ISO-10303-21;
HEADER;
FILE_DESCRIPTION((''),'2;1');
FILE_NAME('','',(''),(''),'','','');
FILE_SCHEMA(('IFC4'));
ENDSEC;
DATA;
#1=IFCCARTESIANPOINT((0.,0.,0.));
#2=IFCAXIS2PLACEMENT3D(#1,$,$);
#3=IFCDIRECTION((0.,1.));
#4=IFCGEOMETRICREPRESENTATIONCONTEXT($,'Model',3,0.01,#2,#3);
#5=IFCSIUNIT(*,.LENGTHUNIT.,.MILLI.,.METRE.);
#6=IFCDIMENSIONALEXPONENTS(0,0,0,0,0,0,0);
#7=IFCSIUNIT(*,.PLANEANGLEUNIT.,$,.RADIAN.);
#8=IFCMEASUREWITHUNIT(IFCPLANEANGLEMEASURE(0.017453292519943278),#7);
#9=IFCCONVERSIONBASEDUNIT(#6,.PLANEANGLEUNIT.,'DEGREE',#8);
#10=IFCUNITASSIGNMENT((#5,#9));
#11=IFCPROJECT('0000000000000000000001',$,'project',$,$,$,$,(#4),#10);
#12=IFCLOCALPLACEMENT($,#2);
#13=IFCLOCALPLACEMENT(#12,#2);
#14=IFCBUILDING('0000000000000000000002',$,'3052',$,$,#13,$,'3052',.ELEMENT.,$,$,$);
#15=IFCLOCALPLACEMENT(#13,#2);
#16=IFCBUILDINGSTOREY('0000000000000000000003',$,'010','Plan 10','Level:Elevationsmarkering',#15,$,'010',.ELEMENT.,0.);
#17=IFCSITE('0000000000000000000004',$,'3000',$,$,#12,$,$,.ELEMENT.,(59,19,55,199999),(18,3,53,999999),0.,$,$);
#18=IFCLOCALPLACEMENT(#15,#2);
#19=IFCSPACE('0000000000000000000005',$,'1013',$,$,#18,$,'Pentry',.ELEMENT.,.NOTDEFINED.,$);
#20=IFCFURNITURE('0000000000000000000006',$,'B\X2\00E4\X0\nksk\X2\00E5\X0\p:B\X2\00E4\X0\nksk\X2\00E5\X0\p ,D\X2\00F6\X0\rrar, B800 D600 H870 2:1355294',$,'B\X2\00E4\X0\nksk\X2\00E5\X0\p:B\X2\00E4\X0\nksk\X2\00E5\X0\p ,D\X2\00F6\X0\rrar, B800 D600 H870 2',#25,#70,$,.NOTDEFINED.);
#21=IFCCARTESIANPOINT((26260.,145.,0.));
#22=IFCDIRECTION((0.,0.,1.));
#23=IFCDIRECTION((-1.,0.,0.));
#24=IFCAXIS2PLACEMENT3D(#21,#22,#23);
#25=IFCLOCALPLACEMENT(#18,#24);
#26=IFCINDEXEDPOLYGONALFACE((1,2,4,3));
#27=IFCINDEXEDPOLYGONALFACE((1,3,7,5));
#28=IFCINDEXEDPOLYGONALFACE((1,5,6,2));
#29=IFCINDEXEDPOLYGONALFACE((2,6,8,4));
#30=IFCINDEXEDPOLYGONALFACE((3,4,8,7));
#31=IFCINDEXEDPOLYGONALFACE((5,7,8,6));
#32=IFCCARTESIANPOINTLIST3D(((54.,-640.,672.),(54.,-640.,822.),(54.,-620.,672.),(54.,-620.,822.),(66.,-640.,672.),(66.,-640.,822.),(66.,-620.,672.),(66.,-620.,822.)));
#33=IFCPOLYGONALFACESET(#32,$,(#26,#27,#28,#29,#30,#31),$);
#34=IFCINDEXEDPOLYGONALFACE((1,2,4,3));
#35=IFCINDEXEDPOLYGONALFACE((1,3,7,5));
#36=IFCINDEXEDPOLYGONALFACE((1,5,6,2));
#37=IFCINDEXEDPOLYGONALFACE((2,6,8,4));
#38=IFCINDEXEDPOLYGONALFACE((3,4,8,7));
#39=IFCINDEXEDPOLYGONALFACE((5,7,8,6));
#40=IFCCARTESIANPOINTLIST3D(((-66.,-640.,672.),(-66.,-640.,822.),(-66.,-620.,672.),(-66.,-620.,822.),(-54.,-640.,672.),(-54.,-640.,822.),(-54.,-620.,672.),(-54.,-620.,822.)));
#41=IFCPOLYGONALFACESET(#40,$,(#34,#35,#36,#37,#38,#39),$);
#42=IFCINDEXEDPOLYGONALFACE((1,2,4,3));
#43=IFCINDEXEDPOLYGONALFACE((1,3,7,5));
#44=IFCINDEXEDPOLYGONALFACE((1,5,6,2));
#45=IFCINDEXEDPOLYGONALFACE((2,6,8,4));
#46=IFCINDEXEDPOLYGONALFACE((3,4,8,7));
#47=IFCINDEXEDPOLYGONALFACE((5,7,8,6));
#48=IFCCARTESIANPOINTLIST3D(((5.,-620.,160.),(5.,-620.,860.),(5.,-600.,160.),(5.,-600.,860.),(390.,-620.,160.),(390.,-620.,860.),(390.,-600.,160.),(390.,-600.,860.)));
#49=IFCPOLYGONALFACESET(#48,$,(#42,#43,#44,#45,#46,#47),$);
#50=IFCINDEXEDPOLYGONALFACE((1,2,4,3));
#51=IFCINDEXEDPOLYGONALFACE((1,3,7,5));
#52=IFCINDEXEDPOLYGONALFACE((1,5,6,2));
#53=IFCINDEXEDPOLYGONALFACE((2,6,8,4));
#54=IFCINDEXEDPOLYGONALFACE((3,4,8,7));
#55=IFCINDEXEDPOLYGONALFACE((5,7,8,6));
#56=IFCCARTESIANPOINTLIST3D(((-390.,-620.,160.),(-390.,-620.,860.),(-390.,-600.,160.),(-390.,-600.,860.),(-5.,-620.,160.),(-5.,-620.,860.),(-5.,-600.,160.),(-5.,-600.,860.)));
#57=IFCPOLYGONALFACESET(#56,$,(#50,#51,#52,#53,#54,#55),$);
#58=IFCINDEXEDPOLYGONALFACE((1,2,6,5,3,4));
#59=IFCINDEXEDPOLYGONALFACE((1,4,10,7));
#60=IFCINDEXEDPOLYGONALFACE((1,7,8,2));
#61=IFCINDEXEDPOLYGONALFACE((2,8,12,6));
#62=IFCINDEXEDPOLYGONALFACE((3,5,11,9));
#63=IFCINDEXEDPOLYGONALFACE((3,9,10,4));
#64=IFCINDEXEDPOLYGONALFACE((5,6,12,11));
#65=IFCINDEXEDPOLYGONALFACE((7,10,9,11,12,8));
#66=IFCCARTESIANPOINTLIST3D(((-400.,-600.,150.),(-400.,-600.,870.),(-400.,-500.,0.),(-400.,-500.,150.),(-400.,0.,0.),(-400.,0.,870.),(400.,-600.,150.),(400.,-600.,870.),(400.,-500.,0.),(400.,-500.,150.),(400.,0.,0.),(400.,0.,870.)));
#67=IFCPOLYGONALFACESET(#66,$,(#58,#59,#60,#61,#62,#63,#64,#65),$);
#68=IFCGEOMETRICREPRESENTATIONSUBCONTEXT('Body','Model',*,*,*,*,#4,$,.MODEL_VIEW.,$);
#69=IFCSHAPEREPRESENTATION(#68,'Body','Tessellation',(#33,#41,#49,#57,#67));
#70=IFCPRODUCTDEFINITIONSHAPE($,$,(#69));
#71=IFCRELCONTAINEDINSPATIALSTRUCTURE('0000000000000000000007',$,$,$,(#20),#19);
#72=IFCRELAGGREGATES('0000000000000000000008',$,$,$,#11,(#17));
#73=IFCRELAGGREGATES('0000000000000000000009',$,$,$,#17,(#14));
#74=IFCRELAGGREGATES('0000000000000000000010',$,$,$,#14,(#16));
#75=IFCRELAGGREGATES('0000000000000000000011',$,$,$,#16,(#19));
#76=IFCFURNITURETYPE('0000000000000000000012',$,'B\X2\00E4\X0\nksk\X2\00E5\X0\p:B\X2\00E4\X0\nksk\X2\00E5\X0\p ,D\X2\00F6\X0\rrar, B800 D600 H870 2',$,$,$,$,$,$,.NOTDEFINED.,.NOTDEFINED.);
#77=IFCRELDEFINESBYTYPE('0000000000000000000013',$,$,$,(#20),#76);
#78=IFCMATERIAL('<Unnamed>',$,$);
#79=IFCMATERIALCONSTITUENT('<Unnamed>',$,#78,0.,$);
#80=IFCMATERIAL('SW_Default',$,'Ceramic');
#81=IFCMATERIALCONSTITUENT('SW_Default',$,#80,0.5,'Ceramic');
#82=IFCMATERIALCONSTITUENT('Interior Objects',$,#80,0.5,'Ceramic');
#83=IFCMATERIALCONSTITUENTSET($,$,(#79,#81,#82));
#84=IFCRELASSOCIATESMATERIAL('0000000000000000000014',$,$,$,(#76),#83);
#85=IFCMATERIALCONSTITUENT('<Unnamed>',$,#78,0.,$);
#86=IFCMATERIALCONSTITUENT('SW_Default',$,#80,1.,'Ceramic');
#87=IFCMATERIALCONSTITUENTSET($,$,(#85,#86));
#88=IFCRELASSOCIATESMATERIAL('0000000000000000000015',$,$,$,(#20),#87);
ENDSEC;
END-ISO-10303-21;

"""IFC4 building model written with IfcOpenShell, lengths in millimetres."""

from ifc_helpers import new_model, entity, si_unit, converted_unit, direction, frame, origin, place, context, subcontext, project, spatial, indexed_curve, outline, extrude, source, transform, mapped, material, constituent, constituent_set, type_object, type_shapes, element, save


model = new_model("IFC4")

# Units and contexts
model_context = context("Model", 3, precision=0.01, world=origin(), true_north=direction((0.0, 1.0)))
body_context = subcontext(model_context, "Body", "Model", "MODEL_VIEW")
ifc_project = project(units=[si_unit("LENGTHUNIT", "METRE", prefix="MILLI"), converted_unit("PLANEANGLEUNIT", "DEGREE", entity("IfcPlaneAngleMeasure", 0.017453292519943278), si_unit("PLANEANGLEUNIT", "RADIAN"), dimensions=[0, 0, 0, 0, 0, 0, 0])], contexts=[model_context])

# Site, building, storey
site_placement = place(None, origin())
site = spatial("IfcSite", under=ifc_project, at=site_placement, Name="3000", CompositionType="ELEMENT", RefLatitude=(59, 19, 55, 199999), RefLongitude=(18, 3, 53, 999999), RefElevation=0.0)
building_placement = place(site_placement, origin())
building = spatial("IfcBuilding", under=site, at=building_placement, Name="3052", LongName="3052", CompositionType="ELEMENT")
storey_placement = place(building_placement, origin())
storey = spatial("IfcBuildingStorey", under=building, at=storey_placement, Name="010", Description="Plan 10", ObjectType="Level:Elevationsmarkering", LongName="010", CompositionType="ELEMENT", Elevation=0.0)

# Shared definitions
space_placement = place(storey_placement, origin())
space = spatial("IfcSpace", under=storey, at=space_placement, Name="1013", LongName="Pentry", CompositionType="ELEMENT", PredefinedType="NOTDEFINED")

# Furniture
ifc_material_1 = material(Name="<Unnamed>")
ifc_constituent_1 = constituent(ifc_material_1, Name="<Unnamed>", fraction=0.0)
ifc_material_2 = material(Name="SW_Default", Category="Ceramic")
ifc_constituent_2 = constituent(ifc_material_2, Name="SW_Default", Category="Ceramic", fraction=1.0)
ifc_constituent_set_1 = constituent_set(constituents=[ifc_constituent_1, ifc_constituent_2])
ifc_constituent_3 = constituent(ifc_material_1, Name="<Unnamed>", fraction=0.0)
ifc_constituent_4 = constituent(ifc_material_2, Name="SW_Default", Category="Ceramic", fraction=0.5)
ifc_constituent_5 = constituent(ifc_material_2, Name="Interior Objects", Category="Ceramic", fraction=0.5)
ifc_constituent_set_2 = constituent_set(constituents=[ifc_constituent_3, ifc_constituent_4, ifc_constituent_5])
furniture_type_1 = type_object("IfcFurnitureType", Name="Bänkskåp:Bänkskåp ,Dörrar, B800 D600 H870 2", AssemblyPlace="NOTDEFINED", PredefinedType="NOTDEFINED", material=ifc_constituent_set_2)
shared_shape_1 = source(origin(), body_context, "Body", "SweptSolid", [
    extrude(outline(indexed_curve([(-6.0, -10.0), (6.0, -10.0), (6.0, 10.0), (-6.0, 10.0), (-6.0, -10.0)], self_intersect=False)), frame((60.0, -630.0, 672.0), z_axis=(0.0, 0.0, 1.0), x_axis=(-1.0, 0.0, 0.0)), (0.0, 0.0, 1.0), 150.0),
    extrude(outline(indexed_curve([(-6.0, -10.0), (6.0, -10.0), (6.0, 10.0), (-6.0, 10.0), (-6.0, -10.0)], self_intersect=False)), frame((-60.0, -630.0, 672.0), z_axis=(0.0, 0.0, 1.0), x_axis=(-1.0, 0.0, 0.0)), (0.0, 0.0, 1.0), 150.0),
    extrude(outline(indexed_curve([(-192.5, -10.0), (192.5, -10.0), (192.5, 10.0), (-192.5, 10.0), (-192.5, -10.0)], self_intersect=False)), frame((197.5, -610.0, 160.0)), (0.0, 0.0, 1.0), 700.0),
    extrude(outline(indexed_curve([(-192.5, -10.0), (192.5, -10.0), (192.5, 10.0), (-192.5, 10.0), (-192.5, -10.0)], self_intersect=False)), frame((-197.5, -610.0, 160.0), z_axis=(0.0, 0.0, 1.0), x_axis=(-1.0, 0.0, 0.0)), (0.0, 0.0, 1.0), 700.0),
    extrude(outline(indexed_curve([(-366.7, -530.0), (233.3, -530.0), (233.3, 190.0), (133.3, 190.0), (133.3, 340.0), (-366.7, 340.0), (-366.7, -530.0)], self_intersect=False)), frame((-400.0, -366.7, 340.0), z_axis=(1.0, 0.0, 0.0), x_axis=(0.0, -1.0, 0.0)), (0.0, 0.0, 1.0), 800.0),
])
type_shapes(furniture_type_1, [shared_shape_1])
furniture_1_placement = place(space_placement, frame((26260.0, 145.0, 0.0), z_axis=(0.0, 0.0, 1.0), x_axis=(-1.0, 0.0, 0.0)))
element("IfcFurniture", 1, at=furniture_1_placement, inside=space, type_object=furniture_type_1, material=ifc_constituent_set_1, Name="Bänkskåp:Bänkskåp ,Dörrar, B800 D600 H870 2:1355294", ObjectType="Bänkskåp:Bänkskåp ,Dörrar, B800 D600 H870 2", PredefinedType="NOTDEFINED", context=body_context, shape_type="MappedRepresentation", body=[
    mapped(shared_shape_1, transform((0.0, 0.0, 0.0), scale=1.0)),
])

save(model, "model.ifc")
